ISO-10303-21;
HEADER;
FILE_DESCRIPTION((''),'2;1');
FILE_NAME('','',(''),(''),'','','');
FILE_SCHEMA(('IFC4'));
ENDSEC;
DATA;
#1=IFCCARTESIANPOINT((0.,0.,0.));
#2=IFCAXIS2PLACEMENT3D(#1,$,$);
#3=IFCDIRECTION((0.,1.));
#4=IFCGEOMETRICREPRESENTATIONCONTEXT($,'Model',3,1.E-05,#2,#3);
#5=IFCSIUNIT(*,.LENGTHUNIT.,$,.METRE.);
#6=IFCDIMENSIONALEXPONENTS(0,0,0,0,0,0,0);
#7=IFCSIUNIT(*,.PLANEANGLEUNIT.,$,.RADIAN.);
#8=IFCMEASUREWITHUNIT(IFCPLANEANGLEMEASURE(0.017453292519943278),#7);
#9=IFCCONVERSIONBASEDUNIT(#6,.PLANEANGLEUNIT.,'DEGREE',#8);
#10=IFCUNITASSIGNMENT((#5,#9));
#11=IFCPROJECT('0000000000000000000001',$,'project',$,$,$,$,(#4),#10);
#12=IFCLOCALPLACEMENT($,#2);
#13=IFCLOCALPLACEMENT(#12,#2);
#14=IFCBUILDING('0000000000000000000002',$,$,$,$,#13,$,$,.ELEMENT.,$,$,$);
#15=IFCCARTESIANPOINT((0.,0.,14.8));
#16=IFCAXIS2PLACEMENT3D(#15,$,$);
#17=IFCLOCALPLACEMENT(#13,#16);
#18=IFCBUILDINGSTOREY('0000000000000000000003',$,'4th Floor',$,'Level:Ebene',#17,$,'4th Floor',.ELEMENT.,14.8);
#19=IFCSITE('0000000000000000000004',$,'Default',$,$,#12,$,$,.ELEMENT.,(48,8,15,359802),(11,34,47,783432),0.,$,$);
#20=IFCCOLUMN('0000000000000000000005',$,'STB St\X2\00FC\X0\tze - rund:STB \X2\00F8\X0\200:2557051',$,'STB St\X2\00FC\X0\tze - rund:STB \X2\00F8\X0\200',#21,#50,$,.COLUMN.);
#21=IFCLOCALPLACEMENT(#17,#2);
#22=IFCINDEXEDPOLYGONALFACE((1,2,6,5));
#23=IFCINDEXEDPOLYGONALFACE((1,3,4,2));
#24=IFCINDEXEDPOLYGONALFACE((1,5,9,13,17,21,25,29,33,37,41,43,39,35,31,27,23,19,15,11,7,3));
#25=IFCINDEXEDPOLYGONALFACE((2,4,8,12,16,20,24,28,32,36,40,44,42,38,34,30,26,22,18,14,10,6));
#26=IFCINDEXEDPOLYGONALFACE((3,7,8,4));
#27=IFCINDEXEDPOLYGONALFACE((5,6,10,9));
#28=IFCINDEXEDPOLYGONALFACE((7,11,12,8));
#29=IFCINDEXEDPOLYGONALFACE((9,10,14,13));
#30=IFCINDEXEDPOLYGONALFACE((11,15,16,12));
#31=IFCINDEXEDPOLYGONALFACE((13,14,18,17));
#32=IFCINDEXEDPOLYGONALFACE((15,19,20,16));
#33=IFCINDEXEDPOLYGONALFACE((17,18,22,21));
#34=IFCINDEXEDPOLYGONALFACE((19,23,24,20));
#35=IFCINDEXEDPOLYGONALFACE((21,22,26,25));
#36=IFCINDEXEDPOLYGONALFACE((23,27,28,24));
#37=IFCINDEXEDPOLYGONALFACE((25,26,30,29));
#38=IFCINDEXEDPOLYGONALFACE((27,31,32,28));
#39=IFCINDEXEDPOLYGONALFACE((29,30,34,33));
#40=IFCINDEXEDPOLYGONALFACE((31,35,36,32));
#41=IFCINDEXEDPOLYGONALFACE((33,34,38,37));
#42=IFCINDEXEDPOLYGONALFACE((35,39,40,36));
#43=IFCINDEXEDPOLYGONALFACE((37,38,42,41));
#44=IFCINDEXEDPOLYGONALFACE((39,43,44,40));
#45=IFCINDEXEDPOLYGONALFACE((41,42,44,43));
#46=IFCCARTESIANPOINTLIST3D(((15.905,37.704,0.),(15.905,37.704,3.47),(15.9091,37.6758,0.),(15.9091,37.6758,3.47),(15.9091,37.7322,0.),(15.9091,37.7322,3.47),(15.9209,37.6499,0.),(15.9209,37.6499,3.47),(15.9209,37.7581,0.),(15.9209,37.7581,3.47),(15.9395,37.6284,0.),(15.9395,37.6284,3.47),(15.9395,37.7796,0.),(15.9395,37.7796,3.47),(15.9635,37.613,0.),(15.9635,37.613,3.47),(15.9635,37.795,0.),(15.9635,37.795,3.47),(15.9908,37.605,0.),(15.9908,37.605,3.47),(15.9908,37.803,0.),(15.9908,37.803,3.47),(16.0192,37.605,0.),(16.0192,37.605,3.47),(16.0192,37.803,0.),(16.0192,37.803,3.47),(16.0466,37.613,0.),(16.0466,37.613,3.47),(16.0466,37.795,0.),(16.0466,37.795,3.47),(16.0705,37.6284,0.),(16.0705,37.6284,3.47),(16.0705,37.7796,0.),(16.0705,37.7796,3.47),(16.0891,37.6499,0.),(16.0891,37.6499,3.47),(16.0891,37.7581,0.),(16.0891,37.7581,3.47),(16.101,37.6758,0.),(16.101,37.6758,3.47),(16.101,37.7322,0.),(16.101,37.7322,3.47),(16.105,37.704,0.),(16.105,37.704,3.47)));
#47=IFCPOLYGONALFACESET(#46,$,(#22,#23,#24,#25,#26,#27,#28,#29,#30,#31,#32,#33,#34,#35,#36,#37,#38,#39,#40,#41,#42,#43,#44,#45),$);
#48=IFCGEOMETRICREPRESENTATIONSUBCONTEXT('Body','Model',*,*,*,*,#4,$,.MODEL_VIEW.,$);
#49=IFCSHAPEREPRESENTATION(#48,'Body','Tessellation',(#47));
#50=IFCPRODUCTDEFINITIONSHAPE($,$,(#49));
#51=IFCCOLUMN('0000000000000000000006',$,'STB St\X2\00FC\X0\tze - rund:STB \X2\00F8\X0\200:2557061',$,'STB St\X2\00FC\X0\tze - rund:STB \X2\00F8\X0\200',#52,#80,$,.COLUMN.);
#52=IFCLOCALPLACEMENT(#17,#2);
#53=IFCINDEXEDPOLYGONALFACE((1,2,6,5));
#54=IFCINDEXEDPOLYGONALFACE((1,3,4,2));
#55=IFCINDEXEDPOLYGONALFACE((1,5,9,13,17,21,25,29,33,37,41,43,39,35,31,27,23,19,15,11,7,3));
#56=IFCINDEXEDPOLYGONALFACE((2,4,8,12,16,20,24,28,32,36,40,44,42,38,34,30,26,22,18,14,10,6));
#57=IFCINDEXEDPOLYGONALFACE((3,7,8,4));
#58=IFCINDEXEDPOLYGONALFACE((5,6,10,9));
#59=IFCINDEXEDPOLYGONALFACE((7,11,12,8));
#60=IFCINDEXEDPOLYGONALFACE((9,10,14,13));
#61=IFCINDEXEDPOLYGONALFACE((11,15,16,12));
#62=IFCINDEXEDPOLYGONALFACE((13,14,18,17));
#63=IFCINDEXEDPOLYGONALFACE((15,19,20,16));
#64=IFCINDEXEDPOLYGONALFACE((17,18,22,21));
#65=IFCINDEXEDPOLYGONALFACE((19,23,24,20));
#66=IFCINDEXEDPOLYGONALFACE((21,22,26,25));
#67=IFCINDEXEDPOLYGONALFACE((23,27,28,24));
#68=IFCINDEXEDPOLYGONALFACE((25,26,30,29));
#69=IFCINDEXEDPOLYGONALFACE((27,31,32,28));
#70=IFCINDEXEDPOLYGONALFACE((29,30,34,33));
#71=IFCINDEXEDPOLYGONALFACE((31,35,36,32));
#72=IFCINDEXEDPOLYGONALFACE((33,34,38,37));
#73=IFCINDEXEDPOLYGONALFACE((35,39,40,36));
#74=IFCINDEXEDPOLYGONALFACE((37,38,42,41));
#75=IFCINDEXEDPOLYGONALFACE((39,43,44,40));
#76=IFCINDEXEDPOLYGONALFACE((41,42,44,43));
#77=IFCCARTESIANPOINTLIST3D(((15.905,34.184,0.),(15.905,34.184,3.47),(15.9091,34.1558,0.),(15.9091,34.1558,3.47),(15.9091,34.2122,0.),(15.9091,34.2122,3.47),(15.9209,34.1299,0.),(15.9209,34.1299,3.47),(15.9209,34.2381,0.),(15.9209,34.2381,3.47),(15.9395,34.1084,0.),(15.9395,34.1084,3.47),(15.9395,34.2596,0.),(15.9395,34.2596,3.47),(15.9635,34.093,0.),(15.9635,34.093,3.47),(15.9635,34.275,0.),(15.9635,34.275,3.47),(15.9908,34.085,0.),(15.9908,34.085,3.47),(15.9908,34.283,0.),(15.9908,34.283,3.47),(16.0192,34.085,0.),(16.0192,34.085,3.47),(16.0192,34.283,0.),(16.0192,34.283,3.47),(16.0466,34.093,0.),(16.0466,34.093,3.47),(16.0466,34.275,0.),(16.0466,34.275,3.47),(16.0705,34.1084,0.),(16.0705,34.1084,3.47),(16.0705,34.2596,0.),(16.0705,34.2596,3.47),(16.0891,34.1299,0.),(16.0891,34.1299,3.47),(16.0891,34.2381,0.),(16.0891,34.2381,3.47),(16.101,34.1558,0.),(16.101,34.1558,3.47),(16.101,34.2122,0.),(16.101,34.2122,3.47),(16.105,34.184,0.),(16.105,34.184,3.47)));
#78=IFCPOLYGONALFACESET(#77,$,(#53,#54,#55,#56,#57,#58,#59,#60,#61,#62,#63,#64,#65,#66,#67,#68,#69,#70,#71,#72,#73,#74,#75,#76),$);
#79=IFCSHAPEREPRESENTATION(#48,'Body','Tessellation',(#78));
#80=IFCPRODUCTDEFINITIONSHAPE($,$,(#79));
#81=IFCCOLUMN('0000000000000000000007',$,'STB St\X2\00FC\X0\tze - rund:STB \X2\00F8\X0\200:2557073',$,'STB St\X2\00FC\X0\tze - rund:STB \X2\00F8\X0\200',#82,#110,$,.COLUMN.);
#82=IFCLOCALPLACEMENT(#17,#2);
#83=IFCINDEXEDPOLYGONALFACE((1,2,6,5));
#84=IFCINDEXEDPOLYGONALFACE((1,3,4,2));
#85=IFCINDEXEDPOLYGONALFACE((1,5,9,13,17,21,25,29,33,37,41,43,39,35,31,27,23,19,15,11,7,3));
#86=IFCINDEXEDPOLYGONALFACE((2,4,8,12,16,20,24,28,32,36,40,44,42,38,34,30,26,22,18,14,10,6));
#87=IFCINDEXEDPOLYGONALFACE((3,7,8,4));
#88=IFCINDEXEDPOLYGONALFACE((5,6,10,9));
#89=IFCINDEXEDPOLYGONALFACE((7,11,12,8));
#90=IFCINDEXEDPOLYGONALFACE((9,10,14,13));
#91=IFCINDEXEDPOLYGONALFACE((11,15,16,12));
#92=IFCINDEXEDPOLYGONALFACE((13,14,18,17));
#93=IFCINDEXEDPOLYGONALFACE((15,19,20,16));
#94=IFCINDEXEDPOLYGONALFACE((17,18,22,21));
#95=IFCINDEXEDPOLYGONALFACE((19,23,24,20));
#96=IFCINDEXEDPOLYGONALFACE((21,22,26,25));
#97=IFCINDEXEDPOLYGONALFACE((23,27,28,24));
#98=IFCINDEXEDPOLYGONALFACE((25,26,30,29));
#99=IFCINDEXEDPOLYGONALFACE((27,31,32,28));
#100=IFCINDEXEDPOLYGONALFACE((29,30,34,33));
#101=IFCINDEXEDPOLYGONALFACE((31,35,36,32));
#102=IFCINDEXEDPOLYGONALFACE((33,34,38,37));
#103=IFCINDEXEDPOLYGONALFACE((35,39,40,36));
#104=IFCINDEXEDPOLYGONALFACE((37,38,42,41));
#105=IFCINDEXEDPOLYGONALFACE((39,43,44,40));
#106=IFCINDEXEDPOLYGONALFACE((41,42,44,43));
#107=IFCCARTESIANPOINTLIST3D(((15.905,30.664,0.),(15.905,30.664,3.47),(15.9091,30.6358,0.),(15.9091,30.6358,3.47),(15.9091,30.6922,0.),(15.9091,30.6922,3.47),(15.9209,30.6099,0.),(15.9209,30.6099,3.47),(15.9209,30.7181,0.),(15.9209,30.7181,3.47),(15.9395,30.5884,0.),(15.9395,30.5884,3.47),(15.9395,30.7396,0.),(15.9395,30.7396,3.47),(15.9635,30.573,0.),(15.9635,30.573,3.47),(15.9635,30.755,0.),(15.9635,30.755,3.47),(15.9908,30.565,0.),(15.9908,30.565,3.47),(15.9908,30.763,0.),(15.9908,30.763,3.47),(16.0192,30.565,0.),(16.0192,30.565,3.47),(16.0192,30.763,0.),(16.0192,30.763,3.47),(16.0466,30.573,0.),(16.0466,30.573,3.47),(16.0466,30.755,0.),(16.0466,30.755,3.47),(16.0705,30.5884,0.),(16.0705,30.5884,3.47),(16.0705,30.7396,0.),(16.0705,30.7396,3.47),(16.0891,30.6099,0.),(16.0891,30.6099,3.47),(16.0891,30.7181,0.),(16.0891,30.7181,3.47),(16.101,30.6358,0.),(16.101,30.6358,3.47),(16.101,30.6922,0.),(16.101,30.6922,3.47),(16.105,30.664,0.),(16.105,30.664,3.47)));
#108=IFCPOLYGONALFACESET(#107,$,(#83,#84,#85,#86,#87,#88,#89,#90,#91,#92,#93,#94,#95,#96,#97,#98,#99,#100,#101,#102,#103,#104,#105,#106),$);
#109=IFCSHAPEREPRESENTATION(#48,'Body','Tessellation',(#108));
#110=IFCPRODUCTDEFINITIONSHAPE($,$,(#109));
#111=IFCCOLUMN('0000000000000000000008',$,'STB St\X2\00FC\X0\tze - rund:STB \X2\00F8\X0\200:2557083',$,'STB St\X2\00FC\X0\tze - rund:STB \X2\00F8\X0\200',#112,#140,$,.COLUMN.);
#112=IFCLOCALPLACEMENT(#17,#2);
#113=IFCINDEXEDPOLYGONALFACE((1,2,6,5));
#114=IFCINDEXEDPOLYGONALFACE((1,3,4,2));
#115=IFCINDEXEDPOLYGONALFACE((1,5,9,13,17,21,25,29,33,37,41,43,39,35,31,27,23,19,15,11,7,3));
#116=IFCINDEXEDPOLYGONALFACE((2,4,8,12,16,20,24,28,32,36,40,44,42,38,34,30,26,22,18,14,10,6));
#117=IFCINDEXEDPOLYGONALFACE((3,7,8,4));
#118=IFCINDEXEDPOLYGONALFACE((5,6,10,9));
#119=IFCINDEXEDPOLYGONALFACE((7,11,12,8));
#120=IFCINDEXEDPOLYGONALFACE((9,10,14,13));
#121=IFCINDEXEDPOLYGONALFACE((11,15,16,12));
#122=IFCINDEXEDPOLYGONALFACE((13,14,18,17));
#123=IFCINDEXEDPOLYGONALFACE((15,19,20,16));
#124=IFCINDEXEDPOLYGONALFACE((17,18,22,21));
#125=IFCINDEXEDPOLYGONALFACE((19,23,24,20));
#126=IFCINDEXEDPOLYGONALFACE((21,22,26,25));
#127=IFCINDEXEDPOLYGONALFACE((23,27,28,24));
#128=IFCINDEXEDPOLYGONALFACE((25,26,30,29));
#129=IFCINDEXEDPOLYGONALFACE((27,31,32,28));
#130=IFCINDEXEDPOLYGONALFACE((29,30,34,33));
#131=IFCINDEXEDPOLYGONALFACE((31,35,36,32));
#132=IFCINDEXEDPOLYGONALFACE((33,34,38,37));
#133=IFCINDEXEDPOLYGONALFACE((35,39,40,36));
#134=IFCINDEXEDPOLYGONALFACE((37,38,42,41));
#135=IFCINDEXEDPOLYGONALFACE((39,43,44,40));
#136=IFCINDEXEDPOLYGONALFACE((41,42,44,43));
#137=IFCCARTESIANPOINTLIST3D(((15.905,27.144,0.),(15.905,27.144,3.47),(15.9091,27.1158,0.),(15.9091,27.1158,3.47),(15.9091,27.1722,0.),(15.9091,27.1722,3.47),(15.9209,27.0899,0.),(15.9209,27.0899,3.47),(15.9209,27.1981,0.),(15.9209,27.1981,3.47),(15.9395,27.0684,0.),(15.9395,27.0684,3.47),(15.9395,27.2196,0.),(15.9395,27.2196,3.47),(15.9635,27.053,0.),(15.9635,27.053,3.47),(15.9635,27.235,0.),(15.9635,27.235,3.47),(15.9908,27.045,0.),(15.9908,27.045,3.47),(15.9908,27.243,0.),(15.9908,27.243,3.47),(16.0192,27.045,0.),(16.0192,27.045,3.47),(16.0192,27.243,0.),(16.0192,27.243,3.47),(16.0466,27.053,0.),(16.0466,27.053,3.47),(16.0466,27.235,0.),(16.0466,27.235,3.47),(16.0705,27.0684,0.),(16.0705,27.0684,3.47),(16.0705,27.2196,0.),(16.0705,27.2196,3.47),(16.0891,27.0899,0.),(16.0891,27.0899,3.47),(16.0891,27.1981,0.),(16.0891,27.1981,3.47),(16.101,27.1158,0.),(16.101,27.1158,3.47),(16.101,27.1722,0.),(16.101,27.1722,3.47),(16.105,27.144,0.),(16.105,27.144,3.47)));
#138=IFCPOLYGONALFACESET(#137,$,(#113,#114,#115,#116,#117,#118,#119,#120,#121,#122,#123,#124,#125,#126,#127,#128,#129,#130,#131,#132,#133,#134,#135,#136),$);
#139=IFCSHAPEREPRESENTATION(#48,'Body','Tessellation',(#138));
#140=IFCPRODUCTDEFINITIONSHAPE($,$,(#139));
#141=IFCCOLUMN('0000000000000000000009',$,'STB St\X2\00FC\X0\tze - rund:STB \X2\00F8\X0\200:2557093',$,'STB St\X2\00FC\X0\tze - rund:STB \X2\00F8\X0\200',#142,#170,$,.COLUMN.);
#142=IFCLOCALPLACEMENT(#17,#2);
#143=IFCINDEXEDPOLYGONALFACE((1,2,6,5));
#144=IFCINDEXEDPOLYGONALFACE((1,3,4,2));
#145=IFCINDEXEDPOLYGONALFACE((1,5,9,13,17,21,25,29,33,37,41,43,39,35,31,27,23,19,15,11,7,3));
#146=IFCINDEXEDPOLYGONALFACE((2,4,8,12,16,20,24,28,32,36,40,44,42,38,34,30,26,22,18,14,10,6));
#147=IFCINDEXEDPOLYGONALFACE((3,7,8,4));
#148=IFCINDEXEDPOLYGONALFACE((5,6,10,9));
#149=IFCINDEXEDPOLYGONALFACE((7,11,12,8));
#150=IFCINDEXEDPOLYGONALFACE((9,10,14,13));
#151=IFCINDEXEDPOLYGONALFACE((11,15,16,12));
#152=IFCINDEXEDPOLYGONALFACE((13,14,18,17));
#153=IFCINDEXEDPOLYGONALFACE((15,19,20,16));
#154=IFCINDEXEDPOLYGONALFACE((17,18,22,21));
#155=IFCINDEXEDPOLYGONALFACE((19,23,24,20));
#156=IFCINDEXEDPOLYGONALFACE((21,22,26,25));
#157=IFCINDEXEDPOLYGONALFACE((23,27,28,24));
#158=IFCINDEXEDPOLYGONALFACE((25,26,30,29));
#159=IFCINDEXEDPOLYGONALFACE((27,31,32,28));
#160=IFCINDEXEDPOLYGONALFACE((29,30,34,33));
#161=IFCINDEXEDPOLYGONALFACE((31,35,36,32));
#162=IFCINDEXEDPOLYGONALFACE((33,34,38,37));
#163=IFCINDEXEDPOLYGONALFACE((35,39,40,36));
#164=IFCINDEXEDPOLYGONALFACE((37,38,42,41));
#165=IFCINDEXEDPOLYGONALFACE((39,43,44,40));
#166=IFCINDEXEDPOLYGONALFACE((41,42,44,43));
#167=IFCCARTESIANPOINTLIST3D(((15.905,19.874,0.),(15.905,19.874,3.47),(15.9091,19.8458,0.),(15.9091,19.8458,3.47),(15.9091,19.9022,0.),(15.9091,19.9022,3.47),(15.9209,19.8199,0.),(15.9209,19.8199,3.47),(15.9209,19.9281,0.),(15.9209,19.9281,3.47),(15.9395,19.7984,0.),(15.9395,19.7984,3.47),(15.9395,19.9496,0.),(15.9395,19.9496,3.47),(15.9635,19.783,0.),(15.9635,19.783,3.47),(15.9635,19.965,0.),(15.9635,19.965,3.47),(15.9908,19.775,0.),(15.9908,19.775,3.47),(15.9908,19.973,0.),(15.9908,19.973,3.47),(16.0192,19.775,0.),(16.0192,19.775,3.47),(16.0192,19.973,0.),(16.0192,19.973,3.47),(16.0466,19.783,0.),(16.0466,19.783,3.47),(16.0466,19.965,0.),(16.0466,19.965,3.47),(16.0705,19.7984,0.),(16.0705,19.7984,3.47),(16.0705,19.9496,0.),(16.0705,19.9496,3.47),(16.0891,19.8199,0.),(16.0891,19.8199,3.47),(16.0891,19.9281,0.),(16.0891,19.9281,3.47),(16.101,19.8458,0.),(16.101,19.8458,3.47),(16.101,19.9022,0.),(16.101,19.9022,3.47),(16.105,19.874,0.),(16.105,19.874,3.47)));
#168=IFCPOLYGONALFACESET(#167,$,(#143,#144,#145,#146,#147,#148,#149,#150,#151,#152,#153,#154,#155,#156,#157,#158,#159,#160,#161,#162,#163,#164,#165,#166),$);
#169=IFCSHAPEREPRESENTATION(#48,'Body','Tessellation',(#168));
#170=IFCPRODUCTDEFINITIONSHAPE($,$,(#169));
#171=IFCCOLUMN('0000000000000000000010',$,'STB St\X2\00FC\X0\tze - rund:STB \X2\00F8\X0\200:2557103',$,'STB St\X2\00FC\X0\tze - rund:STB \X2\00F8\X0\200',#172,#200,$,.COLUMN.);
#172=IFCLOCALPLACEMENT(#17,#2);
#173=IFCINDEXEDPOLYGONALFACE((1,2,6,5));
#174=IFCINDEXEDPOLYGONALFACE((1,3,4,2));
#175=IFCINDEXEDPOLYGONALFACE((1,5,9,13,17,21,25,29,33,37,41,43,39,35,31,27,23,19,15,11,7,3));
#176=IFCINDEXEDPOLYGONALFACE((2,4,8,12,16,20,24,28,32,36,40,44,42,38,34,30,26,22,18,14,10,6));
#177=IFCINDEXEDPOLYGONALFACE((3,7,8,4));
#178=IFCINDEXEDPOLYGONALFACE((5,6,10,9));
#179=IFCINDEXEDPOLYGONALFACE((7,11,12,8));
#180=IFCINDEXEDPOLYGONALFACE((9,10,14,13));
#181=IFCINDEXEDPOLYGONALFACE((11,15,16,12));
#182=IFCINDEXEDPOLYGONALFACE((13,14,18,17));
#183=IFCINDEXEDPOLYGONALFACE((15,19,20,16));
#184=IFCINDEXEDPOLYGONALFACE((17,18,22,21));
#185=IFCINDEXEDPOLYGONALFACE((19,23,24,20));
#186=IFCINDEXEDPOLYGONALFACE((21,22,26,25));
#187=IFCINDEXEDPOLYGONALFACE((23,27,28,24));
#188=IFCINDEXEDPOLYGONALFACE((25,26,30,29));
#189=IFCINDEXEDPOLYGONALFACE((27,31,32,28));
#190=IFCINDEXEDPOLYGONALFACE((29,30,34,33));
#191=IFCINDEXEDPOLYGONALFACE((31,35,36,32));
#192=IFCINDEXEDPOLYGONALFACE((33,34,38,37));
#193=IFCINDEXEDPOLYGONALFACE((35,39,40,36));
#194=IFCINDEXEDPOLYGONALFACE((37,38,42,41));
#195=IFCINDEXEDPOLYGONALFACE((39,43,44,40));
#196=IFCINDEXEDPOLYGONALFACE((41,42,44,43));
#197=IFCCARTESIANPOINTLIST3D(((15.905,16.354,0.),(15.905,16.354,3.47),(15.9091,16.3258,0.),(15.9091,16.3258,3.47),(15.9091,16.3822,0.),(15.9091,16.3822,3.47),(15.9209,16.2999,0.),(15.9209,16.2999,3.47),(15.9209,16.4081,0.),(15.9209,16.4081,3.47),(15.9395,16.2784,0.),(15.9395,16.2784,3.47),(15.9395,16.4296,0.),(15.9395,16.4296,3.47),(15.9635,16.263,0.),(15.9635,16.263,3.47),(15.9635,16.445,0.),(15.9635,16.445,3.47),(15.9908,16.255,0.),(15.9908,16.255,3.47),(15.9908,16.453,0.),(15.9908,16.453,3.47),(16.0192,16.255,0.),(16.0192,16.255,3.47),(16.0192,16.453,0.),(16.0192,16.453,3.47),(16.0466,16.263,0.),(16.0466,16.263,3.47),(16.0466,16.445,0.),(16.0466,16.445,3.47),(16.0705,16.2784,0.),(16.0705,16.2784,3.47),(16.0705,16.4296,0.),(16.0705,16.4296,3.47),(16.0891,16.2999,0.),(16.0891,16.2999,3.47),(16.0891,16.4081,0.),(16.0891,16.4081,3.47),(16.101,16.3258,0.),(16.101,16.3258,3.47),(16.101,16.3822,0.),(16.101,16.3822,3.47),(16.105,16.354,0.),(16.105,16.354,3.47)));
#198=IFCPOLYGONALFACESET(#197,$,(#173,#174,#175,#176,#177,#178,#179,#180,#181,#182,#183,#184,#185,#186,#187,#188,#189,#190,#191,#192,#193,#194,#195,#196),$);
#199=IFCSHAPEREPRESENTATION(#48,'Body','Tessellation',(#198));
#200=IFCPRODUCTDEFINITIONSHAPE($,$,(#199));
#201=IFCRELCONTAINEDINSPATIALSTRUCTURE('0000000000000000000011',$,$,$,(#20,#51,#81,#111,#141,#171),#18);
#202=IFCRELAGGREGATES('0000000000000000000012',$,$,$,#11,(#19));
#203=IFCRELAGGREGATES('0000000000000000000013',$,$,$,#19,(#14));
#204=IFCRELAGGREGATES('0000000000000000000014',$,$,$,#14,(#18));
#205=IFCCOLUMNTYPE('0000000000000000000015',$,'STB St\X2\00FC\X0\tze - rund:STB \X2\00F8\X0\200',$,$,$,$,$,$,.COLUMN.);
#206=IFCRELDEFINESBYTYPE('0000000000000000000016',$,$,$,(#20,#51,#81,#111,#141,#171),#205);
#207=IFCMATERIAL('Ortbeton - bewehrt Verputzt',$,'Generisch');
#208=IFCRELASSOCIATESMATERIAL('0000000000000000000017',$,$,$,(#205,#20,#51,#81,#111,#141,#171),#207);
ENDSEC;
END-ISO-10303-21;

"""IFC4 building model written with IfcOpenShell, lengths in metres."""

from ifc_helpers import new_model, entity, si_unit, converted_unit, direction, frame, origin, place, context, subcontext, project, spatial, arc, indexed_curve, outline, extrude, source, transform, mapped, material, type_object, type_shapes, element, save


model = new_model("IFC4")

# Units and contexts
model_context = context("Model", 3, precision=1e-05, world=origin(), true_north=direction((0.0, 1.0)))
body_context = subcontext(model_context, "Body", "Model", "MODEL_VIEW")
ifc_project = project(units=[si_unit("LENGTHUNIT", "METRE"), converted_unit("PLANEANGLEUNIT", "DEGREE", entity("IfcPlaneAngleMeasure", 0.017453292519943278), si_unit("PLANEANGLEUNIT", "RADIAN"), dimensions=[0, 0, 0, 0, 0, 0, 0])], contexts=[model_context])

# Site, building, storey
site_placement = place(None, origin())
site = spatial("IfcSite", under=ifc_project, at=site_placement, Name="Default", CompositionType="ELEMENT", RefLatitude=(48, 8, 15, 359802), RefLongitude=(11, 34, 47, 783432), RefElevation=0.0)
building_placement = place(site_placement, origin())
building = spatial("IfcBuilding", under=site, at=building_placement, CompositionType="ELEMENT")
storey_placement = place(building_placement, frame((0.0, 0.0, 14.8)))
storey = spatial("IfcBuildingStorey", under=building, at=storey_placement, Name="4th Floor", ObjectType="Level:Ebene", LongName="4th Floor", CompositionType="ELEMENT", Elevation=14.8)

# Columns
ifc_material_1 = material(Name="Ortbeton - bewehrt Verputzt", Category="Generisch")
column_type_1 = type_object("IfcColumnType", Name="STB Stütze - rund:STB ø200", PredefinedType="COLUMN", material=ifc_material_1)
shared_shape_1 = source(origin(), body_context, "Body", "SweptSolid", [
    extrude(outline(indexed_curve([(-0.1, 0.0), (0.0, -0.1), (0.1, 0.0), (0.0, 0.1)], segments=[arc(1, 2, 3), arc(3, 4, 1)], self_intersect=False)), frame((0.0, 0.0, 14.8)), (0.0, 0.0, 1.0), 3.47),
])
type_shapes(column_type_1, [shared_shape_1])
for number, where, name in (
    (1, (16.005, 37.704, -14.8), "STB Stütze - rund:STB ø200:2557051"),
    (2, (16.005, 34.184, -14.8), "STB Stütze - rund:STB ø200:2557061"),
    (3, (16.005, 30.664, -14.8), "STB Stütze - rund:STB ø200:2557073"),
    (4, (16.005, 27.144, -14.8), "STB Stütze - rund:STB ø200:2557083"),
    (5, (16.005, 19.874, -14.8), "STB Stütze - rund:STB ø200:2557093"),
    (6, (16.005, 16.354, -14.8), "STB Stütze - rund:STB ø200:2557103"),
):
    element("IfcColumn", number, at=place(storey_placement, frame(where)), inside=storey, type_object=column_type_1, material=ifc_material_1, Name=name, ObjectType="STB Stütze - rund:STB ø200", PredefinedType="COLUMN", context=body_context, shape_type="MappedRepresentation", body=[
        mapped(shared_shape_1, transform((0.0, 0.0, 0.0), scale=1.0)),
    ])

save(model, "model.ifc")
